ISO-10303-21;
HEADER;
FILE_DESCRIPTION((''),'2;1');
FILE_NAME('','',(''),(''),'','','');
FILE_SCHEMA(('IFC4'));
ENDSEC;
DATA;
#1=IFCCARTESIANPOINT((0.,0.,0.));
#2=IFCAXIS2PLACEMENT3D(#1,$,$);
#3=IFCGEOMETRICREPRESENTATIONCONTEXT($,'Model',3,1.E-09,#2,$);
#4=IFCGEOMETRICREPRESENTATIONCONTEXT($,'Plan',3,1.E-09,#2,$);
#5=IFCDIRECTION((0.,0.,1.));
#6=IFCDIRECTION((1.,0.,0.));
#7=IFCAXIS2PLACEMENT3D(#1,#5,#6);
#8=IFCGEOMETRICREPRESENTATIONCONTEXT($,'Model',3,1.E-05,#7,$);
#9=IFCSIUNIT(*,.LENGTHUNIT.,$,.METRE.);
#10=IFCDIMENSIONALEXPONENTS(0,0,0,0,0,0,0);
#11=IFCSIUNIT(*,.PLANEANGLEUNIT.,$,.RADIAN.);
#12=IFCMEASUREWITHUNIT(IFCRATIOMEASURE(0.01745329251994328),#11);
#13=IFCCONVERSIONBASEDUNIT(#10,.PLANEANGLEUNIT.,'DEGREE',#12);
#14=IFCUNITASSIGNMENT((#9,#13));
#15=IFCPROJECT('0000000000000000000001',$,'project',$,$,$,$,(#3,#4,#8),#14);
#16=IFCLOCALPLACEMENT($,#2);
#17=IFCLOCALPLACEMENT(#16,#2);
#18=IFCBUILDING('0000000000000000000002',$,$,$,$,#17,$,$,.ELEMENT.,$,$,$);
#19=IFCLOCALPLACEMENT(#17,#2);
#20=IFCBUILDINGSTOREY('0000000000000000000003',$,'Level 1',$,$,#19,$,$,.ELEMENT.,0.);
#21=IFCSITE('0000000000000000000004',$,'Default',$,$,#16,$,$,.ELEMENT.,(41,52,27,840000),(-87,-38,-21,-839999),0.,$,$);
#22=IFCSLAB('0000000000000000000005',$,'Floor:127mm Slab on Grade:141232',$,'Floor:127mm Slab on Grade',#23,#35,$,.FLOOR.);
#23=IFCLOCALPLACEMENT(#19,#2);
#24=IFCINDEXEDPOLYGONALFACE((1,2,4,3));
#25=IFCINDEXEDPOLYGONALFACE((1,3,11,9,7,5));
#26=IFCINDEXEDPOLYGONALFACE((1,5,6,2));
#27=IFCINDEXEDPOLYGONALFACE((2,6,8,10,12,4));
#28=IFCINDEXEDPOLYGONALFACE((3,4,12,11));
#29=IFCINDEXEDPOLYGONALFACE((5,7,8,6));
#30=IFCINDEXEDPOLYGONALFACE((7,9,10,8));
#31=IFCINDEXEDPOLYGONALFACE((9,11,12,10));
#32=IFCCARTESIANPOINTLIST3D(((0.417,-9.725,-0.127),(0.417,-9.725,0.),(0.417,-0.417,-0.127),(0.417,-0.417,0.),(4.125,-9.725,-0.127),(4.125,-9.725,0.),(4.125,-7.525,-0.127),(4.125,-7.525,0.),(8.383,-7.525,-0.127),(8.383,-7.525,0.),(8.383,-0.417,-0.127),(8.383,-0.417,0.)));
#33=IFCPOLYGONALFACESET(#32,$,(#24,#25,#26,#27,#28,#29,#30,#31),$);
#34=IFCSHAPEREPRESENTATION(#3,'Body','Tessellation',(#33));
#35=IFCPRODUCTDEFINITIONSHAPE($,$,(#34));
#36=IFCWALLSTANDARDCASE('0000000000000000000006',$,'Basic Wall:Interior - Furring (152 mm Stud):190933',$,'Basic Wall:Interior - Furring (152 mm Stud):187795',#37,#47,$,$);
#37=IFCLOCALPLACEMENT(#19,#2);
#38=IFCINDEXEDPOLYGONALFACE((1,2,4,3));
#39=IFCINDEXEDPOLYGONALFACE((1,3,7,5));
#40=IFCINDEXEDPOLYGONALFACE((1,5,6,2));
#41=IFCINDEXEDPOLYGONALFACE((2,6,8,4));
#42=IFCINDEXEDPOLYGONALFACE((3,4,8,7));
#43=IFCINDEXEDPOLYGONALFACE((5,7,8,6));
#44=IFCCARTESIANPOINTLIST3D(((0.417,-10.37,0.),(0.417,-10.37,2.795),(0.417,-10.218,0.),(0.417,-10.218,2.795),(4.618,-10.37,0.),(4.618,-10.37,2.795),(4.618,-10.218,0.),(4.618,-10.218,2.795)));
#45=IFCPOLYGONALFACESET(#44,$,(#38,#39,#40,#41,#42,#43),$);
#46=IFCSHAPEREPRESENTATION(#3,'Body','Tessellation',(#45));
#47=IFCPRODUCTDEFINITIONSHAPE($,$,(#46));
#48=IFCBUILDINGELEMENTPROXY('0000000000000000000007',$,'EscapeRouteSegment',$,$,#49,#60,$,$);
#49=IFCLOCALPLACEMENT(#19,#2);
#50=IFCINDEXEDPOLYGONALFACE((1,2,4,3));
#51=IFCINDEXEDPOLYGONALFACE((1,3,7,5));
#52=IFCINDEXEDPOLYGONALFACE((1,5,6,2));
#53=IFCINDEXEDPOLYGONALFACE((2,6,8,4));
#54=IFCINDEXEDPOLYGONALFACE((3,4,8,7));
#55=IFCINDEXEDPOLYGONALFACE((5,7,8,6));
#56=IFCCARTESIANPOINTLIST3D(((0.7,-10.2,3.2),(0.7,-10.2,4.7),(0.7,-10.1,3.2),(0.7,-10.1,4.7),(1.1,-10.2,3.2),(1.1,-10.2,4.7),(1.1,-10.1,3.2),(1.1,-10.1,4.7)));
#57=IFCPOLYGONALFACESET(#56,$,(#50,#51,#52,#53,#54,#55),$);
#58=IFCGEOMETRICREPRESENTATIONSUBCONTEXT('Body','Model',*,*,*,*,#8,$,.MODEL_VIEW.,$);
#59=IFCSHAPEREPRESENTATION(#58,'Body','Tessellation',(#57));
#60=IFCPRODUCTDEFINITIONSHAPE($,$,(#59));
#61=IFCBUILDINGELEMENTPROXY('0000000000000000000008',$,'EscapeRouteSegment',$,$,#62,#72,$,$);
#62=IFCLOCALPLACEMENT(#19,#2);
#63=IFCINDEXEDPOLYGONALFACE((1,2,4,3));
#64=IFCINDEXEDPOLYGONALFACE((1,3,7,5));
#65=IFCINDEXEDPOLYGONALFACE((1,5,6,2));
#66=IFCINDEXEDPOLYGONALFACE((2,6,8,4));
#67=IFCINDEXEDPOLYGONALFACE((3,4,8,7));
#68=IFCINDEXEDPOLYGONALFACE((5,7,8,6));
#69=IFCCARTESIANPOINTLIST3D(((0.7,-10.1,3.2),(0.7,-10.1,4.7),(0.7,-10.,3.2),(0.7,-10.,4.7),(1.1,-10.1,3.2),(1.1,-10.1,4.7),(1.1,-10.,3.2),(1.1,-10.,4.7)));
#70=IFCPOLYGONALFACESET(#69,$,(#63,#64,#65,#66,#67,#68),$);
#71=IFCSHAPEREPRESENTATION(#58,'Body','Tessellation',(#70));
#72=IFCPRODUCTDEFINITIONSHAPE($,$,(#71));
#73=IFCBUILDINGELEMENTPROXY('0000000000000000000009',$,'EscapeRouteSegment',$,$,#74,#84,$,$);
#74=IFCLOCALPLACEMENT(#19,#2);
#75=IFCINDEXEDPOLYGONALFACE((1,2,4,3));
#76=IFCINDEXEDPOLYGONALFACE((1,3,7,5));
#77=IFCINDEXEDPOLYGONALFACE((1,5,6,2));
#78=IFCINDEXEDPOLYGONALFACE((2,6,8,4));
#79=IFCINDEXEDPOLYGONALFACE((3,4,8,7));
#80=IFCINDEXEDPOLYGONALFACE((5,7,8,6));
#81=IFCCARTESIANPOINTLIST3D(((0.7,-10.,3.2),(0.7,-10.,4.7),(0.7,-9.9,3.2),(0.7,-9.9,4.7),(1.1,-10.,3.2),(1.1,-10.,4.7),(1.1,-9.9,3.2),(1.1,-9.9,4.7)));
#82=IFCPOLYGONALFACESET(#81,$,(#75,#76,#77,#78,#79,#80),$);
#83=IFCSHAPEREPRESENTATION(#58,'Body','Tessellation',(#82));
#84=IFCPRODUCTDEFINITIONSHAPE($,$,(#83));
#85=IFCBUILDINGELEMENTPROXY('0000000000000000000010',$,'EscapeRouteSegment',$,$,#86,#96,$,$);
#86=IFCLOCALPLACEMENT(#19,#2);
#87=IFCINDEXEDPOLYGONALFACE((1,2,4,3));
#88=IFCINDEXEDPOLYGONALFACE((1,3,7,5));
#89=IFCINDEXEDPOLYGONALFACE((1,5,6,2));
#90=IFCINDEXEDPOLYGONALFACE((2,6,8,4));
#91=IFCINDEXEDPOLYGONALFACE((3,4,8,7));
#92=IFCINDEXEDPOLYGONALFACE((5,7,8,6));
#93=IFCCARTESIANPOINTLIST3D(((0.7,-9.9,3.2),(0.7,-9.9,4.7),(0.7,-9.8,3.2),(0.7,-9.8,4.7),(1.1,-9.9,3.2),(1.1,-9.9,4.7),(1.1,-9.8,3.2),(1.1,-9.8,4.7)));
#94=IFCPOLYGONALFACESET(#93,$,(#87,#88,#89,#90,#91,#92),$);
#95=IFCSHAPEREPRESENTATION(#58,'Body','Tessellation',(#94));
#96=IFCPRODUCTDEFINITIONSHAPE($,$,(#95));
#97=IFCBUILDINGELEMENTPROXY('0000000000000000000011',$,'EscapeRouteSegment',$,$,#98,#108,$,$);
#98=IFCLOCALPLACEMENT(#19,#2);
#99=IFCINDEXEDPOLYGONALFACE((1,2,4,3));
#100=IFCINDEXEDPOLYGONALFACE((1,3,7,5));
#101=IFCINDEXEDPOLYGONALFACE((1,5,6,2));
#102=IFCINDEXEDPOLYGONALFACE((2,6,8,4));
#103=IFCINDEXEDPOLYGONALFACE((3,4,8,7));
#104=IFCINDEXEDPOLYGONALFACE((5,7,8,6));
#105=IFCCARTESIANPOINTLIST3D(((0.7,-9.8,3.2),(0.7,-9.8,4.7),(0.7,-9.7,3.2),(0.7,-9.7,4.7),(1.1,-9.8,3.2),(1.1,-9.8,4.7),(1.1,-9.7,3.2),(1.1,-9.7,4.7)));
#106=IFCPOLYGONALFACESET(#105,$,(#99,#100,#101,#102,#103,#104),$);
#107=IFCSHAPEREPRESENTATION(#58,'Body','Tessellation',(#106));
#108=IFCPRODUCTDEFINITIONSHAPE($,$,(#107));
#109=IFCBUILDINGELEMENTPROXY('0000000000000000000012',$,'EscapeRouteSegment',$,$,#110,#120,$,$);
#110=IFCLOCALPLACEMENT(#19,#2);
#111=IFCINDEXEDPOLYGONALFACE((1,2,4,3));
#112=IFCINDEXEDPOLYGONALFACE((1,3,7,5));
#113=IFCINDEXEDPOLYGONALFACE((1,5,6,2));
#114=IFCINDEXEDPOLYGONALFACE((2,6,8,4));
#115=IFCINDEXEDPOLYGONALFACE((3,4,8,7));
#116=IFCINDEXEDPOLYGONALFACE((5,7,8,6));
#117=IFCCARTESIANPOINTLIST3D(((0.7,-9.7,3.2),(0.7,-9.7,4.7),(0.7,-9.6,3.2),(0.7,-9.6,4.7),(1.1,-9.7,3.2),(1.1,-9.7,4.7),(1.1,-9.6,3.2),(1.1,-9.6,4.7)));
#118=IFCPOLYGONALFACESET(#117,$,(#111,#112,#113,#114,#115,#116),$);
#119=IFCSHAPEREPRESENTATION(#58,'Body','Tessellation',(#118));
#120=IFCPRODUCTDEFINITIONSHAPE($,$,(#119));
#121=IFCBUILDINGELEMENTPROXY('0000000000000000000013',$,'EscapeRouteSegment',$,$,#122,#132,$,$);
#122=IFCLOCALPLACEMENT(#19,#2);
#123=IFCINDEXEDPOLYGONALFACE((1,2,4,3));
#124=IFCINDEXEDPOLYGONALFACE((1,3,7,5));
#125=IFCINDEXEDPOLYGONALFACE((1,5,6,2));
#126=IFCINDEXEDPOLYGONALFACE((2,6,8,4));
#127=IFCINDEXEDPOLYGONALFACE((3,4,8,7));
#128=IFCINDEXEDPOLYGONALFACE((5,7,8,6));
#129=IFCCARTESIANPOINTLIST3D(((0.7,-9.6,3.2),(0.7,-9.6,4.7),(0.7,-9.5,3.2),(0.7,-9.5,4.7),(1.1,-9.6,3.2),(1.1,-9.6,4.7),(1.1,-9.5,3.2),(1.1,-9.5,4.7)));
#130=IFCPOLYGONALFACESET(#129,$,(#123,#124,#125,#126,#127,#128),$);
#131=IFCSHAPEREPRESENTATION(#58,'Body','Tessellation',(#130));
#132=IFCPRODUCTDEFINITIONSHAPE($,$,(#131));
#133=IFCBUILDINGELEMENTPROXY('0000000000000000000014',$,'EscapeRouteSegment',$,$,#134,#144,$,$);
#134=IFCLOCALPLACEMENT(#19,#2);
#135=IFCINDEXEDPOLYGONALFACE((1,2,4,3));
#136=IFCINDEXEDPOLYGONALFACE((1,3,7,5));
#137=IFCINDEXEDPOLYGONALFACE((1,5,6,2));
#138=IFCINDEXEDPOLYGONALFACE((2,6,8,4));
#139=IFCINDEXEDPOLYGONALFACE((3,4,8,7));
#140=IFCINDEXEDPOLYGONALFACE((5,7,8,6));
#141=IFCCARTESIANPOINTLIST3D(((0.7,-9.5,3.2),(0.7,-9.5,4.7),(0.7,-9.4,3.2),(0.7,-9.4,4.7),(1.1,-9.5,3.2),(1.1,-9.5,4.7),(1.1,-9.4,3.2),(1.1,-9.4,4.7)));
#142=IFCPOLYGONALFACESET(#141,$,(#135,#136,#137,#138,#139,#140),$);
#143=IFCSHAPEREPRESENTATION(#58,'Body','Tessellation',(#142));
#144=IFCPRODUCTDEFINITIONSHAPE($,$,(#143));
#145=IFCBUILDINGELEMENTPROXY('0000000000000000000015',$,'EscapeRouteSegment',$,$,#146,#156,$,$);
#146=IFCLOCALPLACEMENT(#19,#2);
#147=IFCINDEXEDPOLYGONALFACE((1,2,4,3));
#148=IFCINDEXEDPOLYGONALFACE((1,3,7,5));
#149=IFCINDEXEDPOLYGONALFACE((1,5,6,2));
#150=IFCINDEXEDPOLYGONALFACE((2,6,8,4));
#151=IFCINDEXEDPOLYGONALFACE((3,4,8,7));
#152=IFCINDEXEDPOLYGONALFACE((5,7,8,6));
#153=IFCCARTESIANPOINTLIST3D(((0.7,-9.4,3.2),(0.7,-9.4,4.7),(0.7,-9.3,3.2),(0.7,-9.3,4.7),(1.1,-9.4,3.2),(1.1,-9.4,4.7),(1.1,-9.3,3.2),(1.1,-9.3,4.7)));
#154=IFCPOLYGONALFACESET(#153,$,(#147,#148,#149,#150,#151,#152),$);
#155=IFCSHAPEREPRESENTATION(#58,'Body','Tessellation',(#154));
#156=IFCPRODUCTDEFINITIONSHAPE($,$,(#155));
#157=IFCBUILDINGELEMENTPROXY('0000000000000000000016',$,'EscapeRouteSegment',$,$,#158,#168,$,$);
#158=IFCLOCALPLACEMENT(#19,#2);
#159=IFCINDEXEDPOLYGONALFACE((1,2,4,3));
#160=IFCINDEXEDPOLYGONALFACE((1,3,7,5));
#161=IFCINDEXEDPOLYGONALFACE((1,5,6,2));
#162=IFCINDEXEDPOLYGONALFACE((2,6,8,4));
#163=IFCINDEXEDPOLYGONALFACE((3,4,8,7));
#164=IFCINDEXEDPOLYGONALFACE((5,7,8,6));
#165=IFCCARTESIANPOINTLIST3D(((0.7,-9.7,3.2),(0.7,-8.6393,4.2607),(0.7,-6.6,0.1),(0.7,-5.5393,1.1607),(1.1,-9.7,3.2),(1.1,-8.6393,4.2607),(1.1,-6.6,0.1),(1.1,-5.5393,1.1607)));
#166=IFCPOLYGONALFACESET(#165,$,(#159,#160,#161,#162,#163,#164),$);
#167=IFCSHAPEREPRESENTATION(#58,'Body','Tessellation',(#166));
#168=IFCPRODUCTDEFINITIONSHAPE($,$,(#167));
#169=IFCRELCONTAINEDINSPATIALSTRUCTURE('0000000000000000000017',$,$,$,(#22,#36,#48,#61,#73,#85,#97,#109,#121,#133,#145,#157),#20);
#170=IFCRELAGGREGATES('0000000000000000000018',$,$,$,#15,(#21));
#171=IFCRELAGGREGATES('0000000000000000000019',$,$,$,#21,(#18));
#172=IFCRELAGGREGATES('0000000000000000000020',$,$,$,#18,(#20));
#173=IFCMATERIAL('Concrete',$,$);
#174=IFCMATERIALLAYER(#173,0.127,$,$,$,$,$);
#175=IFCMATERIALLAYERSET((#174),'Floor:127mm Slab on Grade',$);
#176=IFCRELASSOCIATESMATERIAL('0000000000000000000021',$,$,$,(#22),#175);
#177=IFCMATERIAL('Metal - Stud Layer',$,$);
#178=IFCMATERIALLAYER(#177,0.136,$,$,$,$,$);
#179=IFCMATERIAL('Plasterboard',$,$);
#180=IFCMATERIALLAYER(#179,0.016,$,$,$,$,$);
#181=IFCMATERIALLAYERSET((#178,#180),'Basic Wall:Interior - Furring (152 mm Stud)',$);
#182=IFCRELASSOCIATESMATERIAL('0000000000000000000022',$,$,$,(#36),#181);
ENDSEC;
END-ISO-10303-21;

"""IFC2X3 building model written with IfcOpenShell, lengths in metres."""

from ifc_helpers import new_model, entity, si_unit, converted_unit, frame, frame_2d, origin, origin_with_axes, place, context, subcontext, project, spatial, polyline, rectangle, outline, extrude, material, layer, layer_set, layer_usage, element, save


model = new_model("IFC2X3")

# Units and contexts
model_context_1 = context("Model", 3, precision=1e-09, world=origin())
plan_context = context("Plan", 3, precision=1e-09, world=origin())
model_context_2 = context("Model", 3, precision=1e-05, world=origin_with_axes())
body_context = subcontext(model_context_2, "Body", "Model", "MODEL_VIEW")
ifc_project = project(units=[si_unit("LENGTHUNIT", "METRE"), converted_unit("PLANEANGLEUNIT", "DEGREE", entity("IfcRatioMeasure", 0.01745329251994328), si_unit("PLANEANGLEUNIT", "RADIAN"), dimensions=[0, 0, 0, 0, 0, 0, 0])], contexts=[model_context_1, plan_context, model_context_2])

# Site, building, storey
site_placement = place(None, origin())
site = spatial("IfcSite", under=ifc_project, at=site_placement, Name="Default", CompositionType="ELEMENT", RefLatitude=(41, 52, 27, 840000), RefLongitude=(-87, -38, -21, -839999), RefElevation=0.0)
building_placement = place(site_placement, origin())
building = spatial("IfcBuilding", under=site, at=building_placement, CompositionType="ELEMENT")
storey_placement = place(building_placement, origin())
storey = spatial("IfcBuildingStorey", under=building, at=storey_placement, Name="Level 1", CompositionType="ELEMENT", Elevation=0.0)

# Slab
ifc_material_1 = material(Name="Concrete")
ifc_layer_1 = layer(ifc_material_1, 0.127)
ifc_layer_set_1 = layer_set([ifc_layer_1], Name="Floor:127mm Slab on Grade")
ifc_layer_usage_1 = layer_usage(ifc_layer_set_1, "AXIS3", "POSITIVE", 0.0)
slab_1_placement = place(storey_placement, frame((0.417, -9.725, -0.127)))
element("IfcSlab", 1, at=slab_1_placement, inside=storey, material=ifc_layer_usage_1, Name="Floor:127mm Slab on Grade:141232", ObjectType="Floor:127mm Slab on Grade", PredefinedType="FLOOR", context=model_context_1, shape_type="SweptSolid", body=[
    extrude(outline(polyline([(-3.983, 4.654), (-3.983, -2.454), (0.275, -2.454), (0.275, -4.654), (3.983, -4.654), (3.983, 4.654), (-3.983, 4.654)])), frame((3.983, 4.654, 0.127), z_axis=(0.0, 0.0, -1.0), x_axis=(-1.0, 0.0, 0.0)), (0.0, 0.0, 1.0), 0.127),
])

# Wall
ifc_material_2 = material(Name="Plasterboard")
ifc_material_3 = material(Name="Metal - Stud Layer")
ifc_layer_2 = layer(ifc_material_3, 0.136)
ifc_layer_3 = layer(ifc_material_2, 0.016)
ifc_layer_set_2 = layer_set([ifc_layer_2, ifc_layer_3], Name="Basic Wall:Interior - Furring (152 mm Stud)")
ifc_layer_usage_2 = layer_usage(ifc_layer_set_2, "AXIS2", "NEGATIVE", 0.076)
wall_1_placement = place(storey_placement, frame((0.417, -10.294, 0.0)))
element("IfcWallStandardCase", 2, at=wall_1_placement, inside=storey, material=ifc_layer_usage_2, Name="Basic Wall:Interior - Furring (152 mm Stud):190933", ObjectType="Basic Wall:Interior - Furring (152 mm Stud):187795", context=model_context_1, shape_type="SweptSolid", body=[
    extrude(rectangle(XDim=4.201, YDim=0.152, at=frame_2d((2.1005, 0.0), x_axis=(-1.0, 0.0))), origin(), (0.0, 0.0, 1.0), 2.795),
])

# Building element proxies
proxy_1_placement = place(storey_placement, frame((0.9, -10.2, 3.2), z_axis=(0.0, 0.0, 1.0), x_axis=(0.0, 1.0, 0.0)))
element("IfcBuildingElementProxy", 3, at=proxy_1_placement, inside=storey, Name="EscapeRouteSegment", context=body_context, shape_type="SweptSolid", body=[
    extrude(outline(polyline([(0.0, -0.2), (0.0, 0.2), (0.1, 0.2), (0.1, -0.2), (0.0, -0.2)])), origin_with_axes(), (0.0, 0.0, 1.0), 1.5),
])
for number, where, z_axis, x_axis, name in (
    (4, (0.9, -10.1, 3.2), (0.0, 0.0, 1.0), (0.0, 1.0, 0.0), "EscapeRouteSegment"),
    (5, (0.9, -10.0, 3.2), (0.0, 0.0, 1.0), (0.0, 1.0, 0.0), "EscapeRouteSegment"),
):
    element("IfcBuildingElementProxy", number, at=place(storey_placement, frame(where, z_axis=z_axis, x_axis=x_axis)), inside=storey, Name=name, context=body_context, shape_type="SweptSolid", body=[
        extrude(outline(polyline([(0.0, -0.2), (0.0, 0.2), (0.1, 0.2), (0.1, -0.2), (0.0, -0.2)])), origin_with_axes(), (0.0, 0.0, 1.0), 1.5),
    ])
proxy_2_placement = place(storey_placement, frame((0.9, -9.9, 3.2), z_axis=(0.0, 0.0, 1.0), x_axis=(0.0, 1.0, 0.0)))
element("IfcBuildingElementProxy", 6, at=proxy_2_placement, inside=storey, Name="EscapeRouteSegment", context=body_context, shape_type="SweptSolid", body=[
    extrude(outline(polyline([(0.0, -0.2), (0.0, 0.2), (0.1, 0.2), (0.1, -0.2), (0.0, -0.2)])), origin_with_axes(), (0.0, 0.0, 1.0), 1.5),
])
proxy_3_placement = place(storey_placement, frame((0.9, -9.8, 3.2), z_axis=(0.0, 0.0, 1.0), x_axis=(0.0, 1.0, 0.0)))
element("IfcBuildingElementProxy", 7, at=proxy_3_placement, inside=storey, Name="EscapeRouteSegment", context=body_context, shape_type="SweptSolid", body=[
    extrude(outline(polyline([(0.0, -0.2), (0.0, 0.2), (0.1, 0.2), (0.1, -0.2), (0.0, -0.2)])), origin_with_axes(), (0.0, 0.0, 1.0), 1.5),
])
proxy_4_placement = place(storey_placement, frame((0.9, -9.7, 3.2), z_axis=(0.0, 0.0, 1.0), x_axis=(0.0, 1.0, 0.0)))
element("IfcBuildingElementProxy", 8, at=proxy_4_placement, inside=storey, Name="EscapeRouteSegment", context=body_context, shape_type="SweptSolid", body=[
    extrude(outline(polyline([(0.0, -0.2), (0.0, 0.2), (0.1, 0.2), (0.1, -0.2), (0.0, -0.2)])), origin_with_axes(), (0.0, 0.0, 1.0), 1.5),
])
for number, where, z_axis, x_axis, name in (
    (9, (0.9, -9.6, 3.2), (0.0, 0.0, 1.0), (0.0, 1.0, 0.0), "EscapeRouteSegment"),
    (10, (0.9, -9.5, 3.2), (0.0, 0.0, 1.0), (0.0, 1.0, 0.0), "EscapeRouteSegment"),
):
    element("IfcBuildingElementProxy", number, at=place(storey_placement, frame(where, z_axis=z_axis, x_axis=x_axis)), inside=storey, Name=name, context=body_context, shape_type="SweptSolid", body=[
        extrude(outline(polyline([(0.0, -0.2), (0.0, 0.2), (0.1, 0.2), (0.1, -0.2), (0.0, -0.2)])), origin_with_axes(), (0.0, 0.0, 1.0), 1.5),
    ])
for number, where, z_axis, x_axis, name in (
    (11, (0.9, -9.4, 3.2), (0.0, 0.0, 1.0), (0.0, 1.0, 0.0), "EscapeRouteSegment"),
):
    element("IfcBuildingElementProxy", number, at=place(storey_placement, frame(where, z_axis=z_axis, x_axis=x_axis)), inside=storey, Name=name, context=body_context, shape_type="SweptSolid", body=[
        extrude(outline(polyline([(0.0, -0.2), (0.0, 0.2), (0.1, 0.2), (0.1, -0.2), (0.0, -0.2)])), origin_with_axes(), (0.0, 0.0, 1.0), 1.5),
    ])
proxy_5_placement = place(storey_placement, frame((0.9, -9.7, 3.2), z_axis=(0.0, 0.707107, 0.707107), x_axis=(0.0, 0.707107, -0.707107)))
element("IfcBuildingElementProxy", 12, at=proxy_5_placement, inside=storey, Name="EscapeRouteSegment", context=body_context, shape_type="SweptSolid", body=[
    extrude(outline(polyline([(0.0, -0.2), (0.0, 0.2), (4.3841, 0.2), (4.3841, -0.2), (0.0, -0.2)])), origin_with_axes(), (0.0, 0.0, 1.0), 1.5),
])

save(model, "model.ifc")
